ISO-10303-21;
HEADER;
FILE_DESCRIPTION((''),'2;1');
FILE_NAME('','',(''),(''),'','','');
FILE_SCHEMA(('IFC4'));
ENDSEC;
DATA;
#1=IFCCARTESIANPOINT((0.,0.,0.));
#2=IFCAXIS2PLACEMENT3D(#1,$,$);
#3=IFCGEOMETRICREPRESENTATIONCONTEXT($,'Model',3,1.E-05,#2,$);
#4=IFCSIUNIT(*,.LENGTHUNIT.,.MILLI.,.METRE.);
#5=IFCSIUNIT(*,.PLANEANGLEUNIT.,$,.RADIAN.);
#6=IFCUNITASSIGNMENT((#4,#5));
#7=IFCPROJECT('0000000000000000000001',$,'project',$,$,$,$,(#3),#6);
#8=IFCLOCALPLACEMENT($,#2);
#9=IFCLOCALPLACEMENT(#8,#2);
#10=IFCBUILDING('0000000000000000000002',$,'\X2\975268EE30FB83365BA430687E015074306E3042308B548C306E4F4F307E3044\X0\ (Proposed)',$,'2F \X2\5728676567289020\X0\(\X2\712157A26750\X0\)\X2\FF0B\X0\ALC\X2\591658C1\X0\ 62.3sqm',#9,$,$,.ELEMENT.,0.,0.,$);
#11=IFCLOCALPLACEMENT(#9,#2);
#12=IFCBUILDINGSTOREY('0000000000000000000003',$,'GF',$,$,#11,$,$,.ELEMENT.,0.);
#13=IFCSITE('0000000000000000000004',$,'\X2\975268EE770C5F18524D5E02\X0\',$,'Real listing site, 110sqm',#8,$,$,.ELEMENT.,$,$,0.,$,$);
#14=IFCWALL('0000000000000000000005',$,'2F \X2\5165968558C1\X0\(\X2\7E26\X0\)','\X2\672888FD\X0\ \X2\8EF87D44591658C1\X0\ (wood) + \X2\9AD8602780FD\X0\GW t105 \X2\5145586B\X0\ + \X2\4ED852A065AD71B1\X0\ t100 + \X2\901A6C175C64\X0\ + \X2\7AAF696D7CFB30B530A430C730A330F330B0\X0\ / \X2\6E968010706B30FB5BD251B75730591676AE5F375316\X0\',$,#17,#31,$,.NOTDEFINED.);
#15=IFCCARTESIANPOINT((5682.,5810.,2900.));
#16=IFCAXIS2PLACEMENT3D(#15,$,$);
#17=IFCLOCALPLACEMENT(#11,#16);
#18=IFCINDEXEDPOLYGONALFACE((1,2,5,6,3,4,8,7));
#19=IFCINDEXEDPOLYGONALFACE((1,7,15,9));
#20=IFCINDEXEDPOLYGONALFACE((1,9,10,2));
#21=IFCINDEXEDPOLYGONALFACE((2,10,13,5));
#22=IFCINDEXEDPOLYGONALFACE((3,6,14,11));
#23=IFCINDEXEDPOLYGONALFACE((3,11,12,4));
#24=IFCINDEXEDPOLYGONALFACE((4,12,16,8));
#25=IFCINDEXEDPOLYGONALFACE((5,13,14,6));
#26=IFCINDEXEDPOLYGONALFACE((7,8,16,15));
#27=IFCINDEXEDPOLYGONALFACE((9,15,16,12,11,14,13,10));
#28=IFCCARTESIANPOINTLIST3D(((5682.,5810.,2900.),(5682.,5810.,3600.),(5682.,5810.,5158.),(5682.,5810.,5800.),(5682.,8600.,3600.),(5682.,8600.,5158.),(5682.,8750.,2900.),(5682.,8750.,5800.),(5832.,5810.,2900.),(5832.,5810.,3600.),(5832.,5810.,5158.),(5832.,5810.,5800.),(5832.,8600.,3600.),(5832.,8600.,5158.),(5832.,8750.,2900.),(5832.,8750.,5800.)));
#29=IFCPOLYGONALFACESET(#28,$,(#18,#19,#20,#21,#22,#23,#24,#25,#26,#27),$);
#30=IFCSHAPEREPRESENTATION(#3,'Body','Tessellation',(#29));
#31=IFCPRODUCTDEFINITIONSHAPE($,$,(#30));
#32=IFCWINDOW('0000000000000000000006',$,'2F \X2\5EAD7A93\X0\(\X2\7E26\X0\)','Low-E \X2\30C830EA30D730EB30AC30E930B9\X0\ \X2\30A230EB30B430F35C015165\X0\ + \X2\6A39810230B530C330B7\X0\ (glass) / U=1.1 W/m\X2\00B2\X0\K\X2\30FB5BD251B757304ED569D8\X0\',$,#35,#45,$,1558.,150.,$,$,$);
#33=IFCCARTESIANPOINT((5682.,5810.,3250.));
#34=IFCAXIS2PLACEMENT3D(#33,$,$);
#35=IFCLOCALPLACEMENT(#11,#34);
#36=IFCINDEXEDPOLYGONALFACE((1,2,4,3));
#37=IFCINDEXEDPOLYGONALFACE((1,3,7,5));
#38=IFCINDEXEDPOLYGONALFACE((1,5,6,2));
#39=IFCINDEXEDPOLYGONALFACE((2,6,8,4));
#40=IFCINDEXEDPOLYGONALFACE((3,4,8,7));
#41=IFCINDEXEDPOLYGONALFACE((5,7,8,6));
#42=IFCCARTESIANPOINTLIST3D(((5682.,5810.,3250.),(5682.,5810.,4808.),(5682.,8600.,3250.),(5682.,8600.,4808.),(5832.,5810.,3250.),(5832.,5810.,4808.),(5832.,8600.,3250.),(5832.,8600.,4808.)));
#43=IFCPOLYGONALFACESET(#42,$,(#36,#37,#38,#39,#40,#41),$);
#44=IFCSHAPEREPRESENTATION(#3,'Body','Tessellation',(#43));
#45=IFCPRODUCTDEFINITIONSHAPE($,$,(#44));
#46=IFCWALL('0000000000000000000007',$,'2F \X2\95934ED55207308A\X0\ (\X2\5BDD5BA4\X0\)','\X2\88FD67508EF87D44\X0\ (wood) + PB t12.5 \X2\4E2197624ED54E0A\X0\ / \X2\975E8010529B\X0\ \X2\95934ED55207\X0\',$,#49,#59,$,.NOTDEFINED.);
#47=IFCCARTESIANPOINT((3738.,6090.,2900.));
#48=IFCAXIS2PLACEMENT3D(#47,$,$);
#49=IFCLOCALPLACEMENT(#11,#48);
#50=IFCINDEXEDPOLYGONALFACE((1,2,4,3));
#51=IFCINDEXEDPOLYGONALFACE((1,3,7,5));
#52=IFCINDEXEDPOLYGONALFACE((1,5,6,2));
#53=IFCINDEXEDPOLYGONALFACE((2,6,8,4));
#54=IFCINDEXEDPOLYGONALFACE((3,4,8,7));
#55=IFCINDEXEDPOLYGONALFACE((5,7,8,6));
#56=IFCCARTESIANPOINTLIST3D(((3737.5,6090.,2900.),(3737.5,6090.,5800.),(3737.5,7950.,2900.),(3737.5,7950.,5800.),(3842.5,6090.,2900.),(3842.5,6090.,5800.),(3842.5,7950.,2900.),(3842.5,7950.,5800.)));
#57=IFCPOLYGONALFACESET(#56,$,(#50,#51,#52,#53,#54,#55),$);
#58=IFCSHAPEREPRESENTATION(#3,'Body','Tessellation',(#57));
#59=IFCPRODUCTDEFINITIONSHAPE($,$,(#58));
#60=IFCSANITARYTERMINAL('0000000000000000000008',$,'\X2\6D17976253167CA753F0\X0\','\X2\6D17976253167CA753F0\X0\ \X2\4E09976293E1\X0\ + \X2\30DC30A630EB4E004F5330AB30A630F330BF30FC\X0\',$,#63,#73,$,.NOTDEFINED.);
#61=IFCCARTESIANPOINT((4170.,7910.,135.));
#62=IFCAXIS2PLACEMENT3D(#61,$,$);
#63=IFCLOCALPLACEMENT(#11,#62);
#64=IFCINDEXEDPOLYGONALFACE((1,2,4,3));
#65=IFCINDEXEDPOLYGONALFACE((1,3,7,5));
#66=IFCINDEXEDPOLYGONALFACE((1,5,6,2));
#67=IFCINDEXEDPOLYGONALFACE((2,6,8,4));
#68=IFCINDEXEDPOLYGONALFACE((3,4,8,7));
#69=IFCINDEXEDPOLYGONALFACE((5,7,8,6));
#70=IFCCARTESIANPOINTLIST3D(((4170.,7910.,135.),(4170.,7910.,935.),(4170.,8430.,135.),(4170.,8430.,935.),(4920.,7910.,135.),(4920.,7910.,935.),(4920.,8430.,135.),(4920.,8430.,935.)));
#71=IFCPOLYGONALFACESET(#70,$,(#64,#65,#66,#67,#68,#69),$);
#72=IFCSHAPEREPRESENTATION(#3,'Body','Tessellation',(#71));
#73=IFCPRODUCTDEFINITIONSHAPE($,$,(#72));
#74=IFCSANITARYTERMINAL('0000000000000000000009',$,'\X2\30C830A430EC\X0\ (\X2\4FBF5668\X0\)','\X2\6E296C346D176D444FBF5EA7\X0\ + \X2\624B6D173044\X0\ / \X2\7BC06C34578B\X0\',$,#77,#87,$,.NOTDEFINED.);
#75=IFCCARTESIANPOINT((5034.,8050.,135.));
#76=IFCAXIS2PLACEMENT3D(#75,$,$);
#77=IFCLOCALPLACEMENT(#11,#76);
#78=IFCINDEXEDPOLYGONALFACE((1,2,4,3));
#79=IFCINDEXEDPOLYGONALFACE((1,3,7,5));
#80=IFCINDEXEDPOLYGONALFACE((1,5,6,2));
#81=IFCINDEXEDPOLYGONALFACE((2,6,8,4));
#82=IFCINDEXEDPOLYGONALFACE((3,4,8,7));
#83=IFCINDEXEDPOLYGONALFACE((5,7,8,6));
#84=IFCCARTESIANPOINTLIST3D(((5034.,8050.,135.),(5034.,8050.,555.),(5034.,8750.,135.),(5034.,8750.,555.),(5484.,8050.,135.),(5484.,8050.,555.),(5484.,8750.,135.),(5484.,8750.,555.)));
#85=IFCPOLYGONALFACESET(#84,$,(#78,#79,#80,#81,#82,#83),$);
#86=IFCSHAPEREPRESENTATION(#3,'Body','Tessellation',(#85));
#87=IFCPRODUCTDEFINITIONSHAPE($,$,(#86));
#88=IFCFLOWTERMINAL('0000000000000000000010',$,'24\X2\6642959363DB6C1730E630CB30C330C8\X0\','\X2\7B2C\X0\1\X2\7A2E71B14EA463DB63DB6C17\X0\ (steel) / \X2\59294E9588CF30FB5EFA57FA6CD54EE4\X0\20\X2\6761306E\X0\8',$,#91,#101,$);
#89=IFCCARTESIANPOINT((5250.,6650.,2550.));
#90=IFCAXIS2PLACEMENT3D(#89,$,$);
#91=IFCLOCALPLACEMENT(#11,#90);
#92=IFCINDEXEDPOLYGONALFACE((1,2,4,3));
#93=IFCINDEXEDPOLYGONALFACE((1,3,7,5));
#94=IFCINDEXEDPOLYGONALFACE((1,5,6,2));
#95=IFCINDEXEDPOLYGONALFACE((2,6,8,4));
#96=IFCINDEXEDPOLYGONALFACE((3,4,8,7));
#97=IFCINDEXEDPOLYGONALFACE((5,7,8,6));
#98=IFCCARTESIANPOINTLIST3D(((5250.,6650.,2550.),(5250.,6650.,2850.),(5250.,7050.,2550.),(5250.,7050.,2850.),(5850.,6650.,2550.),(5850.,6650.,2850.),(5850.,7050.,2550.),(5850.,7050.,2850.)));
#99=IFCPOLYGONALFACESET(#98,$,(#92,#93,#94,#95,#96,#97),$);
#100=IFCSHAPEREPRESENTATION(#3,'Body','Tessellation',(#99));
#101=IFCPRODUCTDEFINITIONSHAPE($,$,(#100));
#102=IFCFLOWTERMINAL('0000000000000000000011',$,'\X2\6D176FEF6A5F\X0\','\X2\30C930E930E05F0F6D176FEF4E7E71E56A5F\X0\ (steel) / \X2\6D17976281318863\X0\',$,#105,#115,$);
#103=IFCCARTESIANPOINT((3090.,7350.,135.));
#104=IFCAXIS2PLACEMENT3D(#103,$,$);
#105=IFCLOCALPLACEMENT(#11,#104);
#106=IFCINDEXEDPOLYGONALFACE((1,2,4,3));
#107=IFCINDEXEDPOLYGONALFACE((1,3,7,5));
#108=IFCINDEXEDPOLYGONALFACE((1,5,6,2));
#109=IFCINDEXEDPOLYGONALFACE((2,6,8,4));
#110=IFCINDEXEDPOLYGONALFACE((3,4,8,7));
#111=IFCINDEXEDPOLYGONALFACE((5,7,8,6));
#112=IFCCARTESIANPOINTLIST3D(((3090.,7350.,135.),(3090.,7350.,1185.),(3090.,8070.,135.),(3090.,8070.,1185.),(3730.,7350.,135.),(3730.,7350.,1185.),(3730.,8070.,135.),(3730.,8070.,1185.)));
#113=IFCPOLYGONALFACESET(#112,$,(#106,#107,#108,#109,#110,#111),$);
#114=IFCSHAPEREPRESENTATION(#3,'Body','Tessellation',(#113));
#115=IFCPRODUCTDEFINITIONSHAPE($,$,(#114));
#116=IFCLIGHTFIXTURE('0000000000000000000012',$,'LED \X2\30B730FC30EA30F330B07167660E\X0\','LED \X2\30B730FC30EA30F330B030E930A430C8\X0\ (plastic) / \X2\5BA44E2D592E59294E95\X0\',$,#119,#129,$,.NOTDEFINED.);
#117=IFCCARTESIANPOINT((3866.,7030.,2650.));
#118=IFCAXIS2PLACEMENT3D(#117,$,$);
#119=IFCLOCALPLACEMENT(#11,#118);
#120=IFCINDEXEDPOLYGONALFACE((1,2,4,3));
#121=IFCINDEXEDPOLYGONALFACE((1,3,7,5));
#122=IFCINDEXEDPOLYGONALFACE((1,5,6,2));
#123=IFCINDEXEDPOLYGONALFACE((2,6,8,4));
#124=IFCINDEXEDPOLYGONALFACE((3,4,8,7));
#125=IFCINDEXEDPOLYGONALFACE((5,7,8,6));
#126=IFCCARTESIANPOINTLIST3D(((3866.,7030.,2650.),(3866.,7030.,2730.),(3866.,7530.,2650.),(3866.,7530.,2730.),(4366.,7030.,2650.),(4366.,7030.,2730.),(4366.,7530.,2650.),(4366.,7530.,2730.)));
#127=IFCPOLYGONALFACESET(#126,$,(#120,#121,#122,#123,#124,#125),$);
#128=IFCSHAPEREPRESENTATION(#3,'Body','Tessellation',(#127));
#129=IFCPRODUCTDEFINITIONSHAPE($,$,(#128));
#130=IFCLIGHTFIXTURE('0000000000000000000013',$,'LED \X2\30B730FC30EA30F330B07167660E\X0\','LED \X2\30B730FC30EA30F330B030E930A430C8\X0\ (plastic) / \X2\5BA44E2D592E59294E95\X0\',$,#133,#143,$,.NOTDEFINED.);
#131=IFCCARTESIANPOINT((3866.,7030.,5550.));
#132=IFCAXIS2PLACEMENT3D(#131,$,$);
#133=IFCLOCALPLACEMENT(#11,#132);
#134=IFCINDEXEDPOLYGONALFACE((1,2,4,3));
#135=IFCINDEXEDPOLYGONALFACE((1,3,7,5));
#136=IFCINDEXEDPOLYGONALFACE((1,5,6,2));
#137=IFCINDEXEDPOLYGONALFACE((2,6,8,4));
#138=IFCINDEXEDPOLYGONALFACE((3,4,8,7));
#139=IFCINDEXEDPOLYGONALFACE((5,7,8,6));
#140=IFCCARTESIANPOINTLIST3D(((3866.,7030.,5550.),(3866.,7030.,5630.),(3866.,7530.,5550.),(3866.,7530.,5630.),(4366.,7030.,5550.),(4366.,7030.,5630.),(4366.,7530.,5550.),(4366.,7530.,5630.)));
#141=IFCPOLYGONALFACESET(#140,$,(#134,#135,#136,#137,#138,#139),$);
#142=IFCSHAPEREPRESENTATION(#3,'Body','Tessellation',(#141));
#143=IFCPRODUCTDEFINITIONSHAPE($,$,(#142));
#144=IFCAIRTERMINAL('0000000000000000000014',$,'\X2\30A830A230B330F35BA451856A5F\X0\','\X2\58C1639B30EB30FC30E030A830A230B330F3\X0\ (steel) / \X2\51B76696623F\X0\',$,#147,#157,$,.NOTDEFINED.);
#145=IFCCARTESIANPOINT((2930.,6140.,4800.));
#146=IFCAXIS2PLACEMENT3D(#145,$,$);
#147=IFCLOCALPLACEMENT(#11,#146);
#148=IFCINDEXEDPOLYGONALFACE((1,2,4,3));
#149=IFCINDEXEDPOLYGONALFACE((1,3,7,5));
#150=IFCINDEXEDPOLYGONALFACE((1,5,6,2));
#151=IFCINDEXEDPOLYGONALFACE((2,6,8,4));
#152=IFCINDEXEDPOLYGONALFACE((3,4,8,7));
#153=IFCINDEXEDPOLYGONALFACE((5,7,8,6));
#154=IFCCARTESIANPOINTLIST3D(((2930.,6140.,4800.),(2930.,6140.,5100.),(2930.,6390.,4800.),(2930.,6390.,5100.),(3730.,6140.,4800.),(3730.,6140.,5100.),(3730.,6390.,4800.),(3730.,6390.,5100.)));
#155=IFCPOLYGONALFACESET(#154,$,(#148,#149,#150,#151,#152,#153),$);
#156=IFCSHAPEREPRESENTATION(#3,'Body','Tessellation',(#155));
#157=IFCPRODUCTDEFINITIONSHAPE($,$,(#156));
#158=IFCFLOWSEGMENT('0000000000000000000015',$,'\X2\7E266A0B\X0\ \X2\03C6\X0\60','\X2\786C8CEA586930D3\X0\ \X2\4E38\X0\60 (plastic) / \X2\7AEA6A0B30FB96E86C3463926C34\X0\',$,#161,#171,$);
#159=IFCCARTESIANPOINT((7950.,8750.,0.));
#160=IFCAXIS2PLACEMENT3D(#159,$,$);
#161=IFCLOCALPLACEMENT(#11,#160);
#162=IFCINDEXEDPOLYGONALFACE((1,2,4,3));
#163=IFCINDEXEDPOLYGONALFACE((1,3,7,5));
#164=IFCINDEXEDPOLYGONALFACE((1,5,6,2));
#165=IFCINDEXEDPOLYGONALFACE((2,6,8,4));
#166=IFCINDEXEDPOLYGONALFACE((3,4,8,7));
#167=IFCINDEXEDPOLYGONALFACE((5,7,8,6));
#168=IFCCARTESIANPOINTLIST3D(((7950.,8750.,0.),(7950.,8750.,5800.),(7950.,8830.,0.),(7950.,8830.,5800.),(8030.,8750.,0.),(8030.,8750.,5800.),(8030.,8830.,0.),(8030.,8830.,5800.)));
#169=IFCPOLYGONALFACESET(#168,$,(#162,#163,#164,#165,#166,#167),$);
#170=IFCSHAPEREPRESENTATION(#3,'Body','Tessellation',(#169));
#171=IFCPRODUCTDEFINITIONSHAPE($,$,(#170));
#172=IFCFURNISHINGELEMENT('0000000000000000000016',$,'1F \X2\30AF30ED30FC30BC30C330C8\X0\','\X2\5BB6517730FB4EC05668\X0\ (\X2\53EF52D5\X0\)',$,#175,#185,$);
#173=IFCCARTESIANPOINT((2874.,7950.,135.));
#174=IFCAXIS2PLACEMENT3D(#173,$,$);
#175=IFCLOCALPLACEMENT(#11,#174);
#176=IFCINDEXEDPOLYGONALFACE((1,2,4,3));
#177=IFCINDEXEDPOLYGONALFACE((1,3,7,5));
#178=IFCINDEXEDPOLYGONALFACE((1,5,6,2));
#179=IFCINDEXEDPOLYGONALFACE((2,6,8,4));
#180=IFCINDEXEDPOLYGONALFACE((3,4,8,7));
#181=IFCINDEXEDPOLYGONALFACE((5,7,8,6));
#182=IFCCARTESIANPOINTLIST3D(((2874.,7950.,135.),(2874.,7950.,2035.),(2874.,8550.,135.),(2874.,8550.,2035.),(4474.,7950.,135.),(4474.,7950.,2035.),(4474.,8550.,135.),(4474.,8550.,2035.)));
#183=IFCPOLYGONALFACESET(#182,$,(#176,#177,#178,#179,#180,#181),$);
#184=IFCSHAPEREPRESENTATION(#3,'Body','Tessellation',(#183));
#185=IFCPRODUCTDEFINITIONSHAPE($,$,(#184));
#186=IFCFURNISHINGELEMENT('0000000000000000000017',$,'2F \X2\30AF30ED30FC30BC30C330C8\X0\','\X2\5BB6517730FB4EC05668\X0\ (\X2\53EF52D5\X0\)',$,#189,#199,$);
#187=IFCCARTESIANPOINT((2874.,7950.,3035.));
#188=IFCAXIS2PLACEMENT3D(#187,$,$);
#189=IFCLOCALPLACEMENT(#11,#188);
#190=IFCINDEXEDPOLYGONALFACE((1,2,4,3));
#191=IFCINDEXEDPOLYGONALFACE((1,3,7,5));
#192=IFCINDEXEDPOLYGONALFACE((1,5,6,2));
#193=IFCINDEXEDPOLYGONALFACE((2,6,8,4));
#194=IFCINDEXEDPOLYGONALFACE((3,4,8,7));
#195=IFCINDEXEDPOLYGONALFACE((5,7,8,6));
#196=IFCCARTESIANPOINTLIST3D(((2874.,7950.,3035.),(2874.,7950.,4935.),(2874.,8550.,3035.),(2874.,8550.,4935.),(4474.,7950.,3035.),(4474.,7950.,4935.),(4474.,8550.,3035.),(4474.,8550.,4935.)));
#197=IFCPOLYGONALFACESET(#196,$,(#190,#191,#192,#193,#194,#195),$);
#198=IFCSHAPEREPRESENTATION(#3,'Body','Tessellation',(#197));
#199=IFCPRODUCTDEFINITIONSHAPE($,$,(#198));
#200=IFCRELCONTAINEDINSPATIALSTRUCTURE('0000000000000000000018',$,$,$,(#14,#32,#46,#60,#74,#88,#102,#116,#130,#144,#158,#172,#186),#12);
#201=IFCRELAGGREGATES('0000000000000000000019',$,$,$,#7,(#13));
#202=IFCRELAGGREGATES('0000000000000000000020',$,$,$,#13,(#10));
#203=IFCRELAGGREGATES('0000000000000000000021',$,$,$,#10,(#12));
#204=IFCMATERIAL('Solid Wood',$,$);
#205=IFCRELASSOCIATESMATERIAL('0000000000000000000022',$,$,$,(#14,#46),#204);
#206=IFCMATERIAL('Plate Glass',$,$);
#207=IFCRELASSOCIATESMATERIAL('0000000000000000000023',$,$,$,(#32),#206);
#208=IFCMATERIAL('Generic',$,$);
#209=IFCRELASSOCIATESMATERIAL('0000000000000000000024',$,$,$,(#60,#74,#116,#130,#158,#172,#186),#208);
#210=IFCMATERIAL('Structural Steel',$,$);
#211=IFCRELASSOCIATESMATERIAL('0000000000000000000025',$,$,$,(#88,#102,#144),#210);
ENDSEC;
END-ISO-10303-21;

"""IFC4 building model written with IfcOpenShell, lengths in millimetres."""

from ifc_helpers import new_model, si_unit, frame, frame_2d, origin, place, context, project, spatial, rectangle, extrude, material, element, fill, save


model = new_model("IFC4")

# Units and contexts
model_context = context("Model", 3, precision=1e-05, world=origin())
ifc_project = project(units=[si_unit("LENGTHUNIT", "METRE", prefix="MILLI"), si_unit("PLANEANGLEUNIT", "RADIAN")], contexts=[model_context])

# Site, building, storey
site_placement = place(None, origin())
site = spatial("IfcSite", under=ifc_project, at=site_placement, Name="青森県弘前市", ObjectType="Real listing site, 110sqm", CompositionType="ELEMENT", RefElevation=0.0)
building_placement = place(site_placement, origin())
building = spatial("IfcBuilding", under=site, at=building_placement, Name="青森・茶室と縁側のある和の住まい (Proposed)", ObjectType="2F 在来木造(無垢材)＋ALC外壁 62.3sqm", CompositionType="ELEMENT", ElevationOfRefHeight=0.0, ElevationOfTerrain=0.0)
storey_placement = place(building_placement, origin())
storey = spatial("IfcBuildingStorey", under=building, at=storey_placement, Name="GF", CompositionType="ELEMENT", Elevation=0.0)

# Shared definitions
ifc_material_1 = material(Name="Solid Wood")

# Shared definitions
ifc_material_2 = material(Name="Plate Glass")

# Wall, opening, window
wall_1_placement = place(storey_placement, frame((5682.0, 5810.0, 2900.0)))
wall_1 = element("IfcWall", 1, at=wall_1_placement, inside=storey, material=ifc_material_1, Name="2F 入隅壁(縦)", Description="木製 軸組外壁 (wood) + 高性能GW t105 充填 + 付加断熱 t100 + 通気層 + 窯業系サイディング / 準耐火・寒冷地外皮強化", PredefinedType="NOTDEFINED", context=model_context, shape_type="SweptSolid", body=[
    extrude(rectangle(XDim=150.0, YDim=2940.0, at=frame_2d((75.0, 1470.0))), frame((5682.0, 5810.0, 2900.0)), (0.0, 0.0, 1.0), 2900.0),
])
opening_1_placement = place(storey_placement, frame((5682.0, 5810.0, 3250.0)))
opening_1 = element("IfcOpeningElement", 2, at=opening_1_placement, cuts=wall_1, PredefinedType="NOTDEFINED", context=model_context, shape_type="SweptSolid", body=[
    extrude(rectangle(XDim=150.0, YDim=2790.0, at=frame_2d((75.0, 1395.0))), frame((5682.0, 5810.0, 3250.0)), (0.0, 0.0, 1.0), 1558.0),
])
window_1_placement = place(storey_placement, frame((5682.0, 5810.0, 3250.0)))
window_1 = element("IfcWindow", 3, at=window_1_placement, inside=storey, material=ifc_material_2, Name="2F 庭窓(縦)", Description="Low-E トリプルガラス アルゴン封入 + 樹脂サッシ (glass) / U=1.1 W/m²K・寒冷地仕様", OverallHeight=1558.0, OverallWidth=150.0, context=model_context, shape_type="SweptSolid", body=[
    extrude(rectangle(XDim=150.0, YDim=2790.0, at=frame_2d((75.0, 1395.0))), frame((5682.0, 5810.0, 3250.0)), (0.0, 0.0, 1.0), 1558.0),
])
fill(opening_1, window_1)

# Wall
wall_2_placement = place(storey_placement, frame((3738.0, 6090.0, 2900.0)))
element("IfcWall", 4, at=wall_2_placement, inside=storey, material=ifc_material_1, Name="2F 間仕切り (寝室)", Description="製材軸組 (wood) + PB t12.5 両面仕上 / 非耐力 間仕切", PredefinedType="NOTDEFINED", context=model_context, shape_type="SweptSolid", body=[
    extrude(rectangle(XDim=105.0, YDim=1860.0, at=frame_2d((52.0, 930.0))), frame((3738.0, 6090.0, 2900.0)), (0.0, 0.0, 1.0), 2900.0),
])

# Sanitary terminals
ifc_material_3 = material(Name="Generic")
sanitary_terminal_1_placement = place(storey_placement, frame((4170.0, 7910.0, 135.0)))
element("IfcSanitaryTerminal", 5, at=sanitary_terminal_1_placement, inside=storey, material=ifc_material_3, Name="洗面化粧台", Description="洗面化粧台 三面鏡 + ボウル一体カウンター", PredefinedType="NOTDEFINED", context=model_context, shape_type="SweptSolid", body=[
    extrude(rectangle(XDim=750.0, YDim=520.0, at=frame_2d((375.0, 260.0))), frame((4170.0, 7910.0, 135.0)), (0.0, 0.0, 1.0), 800.0),
])
sanitary_terminal_2_placement = place(storey_placement, frame((5034.0, 8050.0, 135.0)))
element("IfcSanitaryTerminal", 6, at=sanitary_terminal_2_placement, inside=storey, material=ifc_material_3, Name="トイレ (便器)", Description="温水洗浄便座 + 手洗い / 節水型", PredefinedType="NOTDEFINED", context=model_context, shape_type="SweptSolid", body=[
    extrude(rectangle(XDim=450.0, YDim=700.0, at=frame_2d((225.0, 350.0))), frame((5034.0, 8050.0, 135.0)), (0.0, 0.0, 1.0), 420.0),
])

# Flow terminals
ifc_material_4 = material(Name="Structural Steel")
flow_terminal_1_placement = place(storey_placement, frame((5250.0, 6650.0, 2550.0)))
element("IfcFlowTerminal", 7, at=flow_terminal_1_placement, inside=storey, material=ifc_material_4, Name="24時間換気ユニット", Description="第1種熱交換換気 (steel) / 天井裏・建基法令20条の8", context=model_context, shape_type="SweptSolid", body=[
    extrude(rectangle(XDim=600.0, YDim=400.0, at=frame_2d((300.0, 200.0))), frame((5250.0, 6650.0, 2550.0)), (0.0, 0.0, 1.0), 300.0),
])
flow_terminal_2_placement = place(storey_placement, frame((3090.0, 7350.0, 135.0)))
element("IfcFlowTerminal", 8, at=flow_terminal_2_placement, inside=storey, material=ifc_material_4, Name="洗濯機", Description="ドラム式洗濯乾燥機 (steel) / 洗面脱衣", context=model_context, shape_type="SweptSolid", body=[
    extrude(rectangle(XDim=640.0, YDim=720.0, at=frame_2d((320.0, 360.0))), frame((3090.0, 7350.0, 135.0)), (0.0, 0.0, 1.0), 1050.0),
])

# Light fixtures
light_fixture_1_placement = place(storey_placement, frame((3866.0, 7030.0, 2650.0)))
element("IfcLightFixture", 9, at=light_fixture_1_placement, inside=storey, material=ifc_material_3, Name="LED シーリング照明", Description="LED シーリングライト (plastic) / 室中央天井", PredefinedType="NOTDEFINED", context=model_context, shape_type="SweptSolid", body=[
    extrude(rectangle(XDim=500.0, YDim=500.0, at=frame_2d((250.0, 250.0))), frame((3866.0, 7030.0, 2650.0)), (0.0, 0.0, 1.0), 80.0),
])
light_fixture_2_placement = place(storey_placement, frame((3866.0, 7030.0, 5550.0)))
element("IfcLightFixture", 10, at=light_fixture_2_placement, inside=storey, material=ifc_material_3, Name="LED シーリング照明", Description="LED シーリングライト (plastic) / 室中央天井", PredefinedType="NOTDEFINED", context=model_context, shape_type="SweptSolid", body=[
    extrude(rectangle(XDim=500.0, YDim=500.0, at=frame_2d((250.0, 250.0))), frame((3866.0, 7030.0, 5550.0)), (0.0, 0.0, 1.0), 80.0),
])

# Air terminal
air_terminal_placement = place(storey_placement, frame((2930.0, 6140.0, 4800.0)))
element("IfcAirTerminal", 11, at=air_terminal_placement, inside=storey, material=ifc_material_4, Name="エアコン室内機", Description="壁掛ルームエアコン (steel) / 冷暖房", PredefinedType="NOTDEFINED", context=model_context, shape_type="SweptSolid", body=[
    extrude(rectangle(XDim=800.0, YDim=250.0, at=frame_2d((400.0, 125.0))), frame((2930.0, 6140.0, 4800.0)), (0.0, 0.0, 1.0), 300.0),
])

# Flow segment
flow_segment_placement = place(storey_placement, frame((7950.0, 8750.0, 0.0)))
element("IfcFlowSegment", 12, at=flow_segment_placement, inside=storey, material=ifc_material_3, Name="縦樋 φ60", Description="硬質塩ビ 丸60 (plastic) / 竪樋・雨水排水", context=model_context, shape_type="SweptSolid", body=[
    extrude(rectangle(XDim=80.0, YDim=80.0, at=frame_2d((40.0, 40.0))), frame((7950.0, 8750.0, 0.0)), (0.0, 0.0, 1.0), 5800.0),
])

# Furnishing elements
furnishing_1_placement = place(storey_placement, frame((2874.0, 7950.0, 135.0)))
element("IfcFurnishingElement", 13, at=furnishing_1_placement, inside=storey, material=ifc_material_3, Name="1F クローゼット", Description="家具・什器 (可動)", context=model_context, shape_type="SweptSolid", body=[
    extrude(rectangle(XDim=1600.0, YDim=600.0, at=frame_2d((800.0, 300.0))), frame((2874.0, 7950.0, 135.0)), (0.0, 0.0, 1.0), 1900.0),
])
furnishing_2_placement = place(storey_placement, frame((2874.0, 7950.0, 3035.0)))
element("IfcFurnishingElement", 14, at=furnishing_2_placement, inside=storey, material=ifc_material_3, Name="2F クローゼット", Description="家具・什器 (可動)", context=model_context, shape_type="SweptSolid", body=[
    extrude(rectangle(XDim=1600.0, YDim=600.0, at=frame_2d((800.0, 300.0))), frame((2874.0, 7950.0, 3035.0)), (0.0, 0.0, 1.0), 1900.0),
])

save(model, "model.ifc")
